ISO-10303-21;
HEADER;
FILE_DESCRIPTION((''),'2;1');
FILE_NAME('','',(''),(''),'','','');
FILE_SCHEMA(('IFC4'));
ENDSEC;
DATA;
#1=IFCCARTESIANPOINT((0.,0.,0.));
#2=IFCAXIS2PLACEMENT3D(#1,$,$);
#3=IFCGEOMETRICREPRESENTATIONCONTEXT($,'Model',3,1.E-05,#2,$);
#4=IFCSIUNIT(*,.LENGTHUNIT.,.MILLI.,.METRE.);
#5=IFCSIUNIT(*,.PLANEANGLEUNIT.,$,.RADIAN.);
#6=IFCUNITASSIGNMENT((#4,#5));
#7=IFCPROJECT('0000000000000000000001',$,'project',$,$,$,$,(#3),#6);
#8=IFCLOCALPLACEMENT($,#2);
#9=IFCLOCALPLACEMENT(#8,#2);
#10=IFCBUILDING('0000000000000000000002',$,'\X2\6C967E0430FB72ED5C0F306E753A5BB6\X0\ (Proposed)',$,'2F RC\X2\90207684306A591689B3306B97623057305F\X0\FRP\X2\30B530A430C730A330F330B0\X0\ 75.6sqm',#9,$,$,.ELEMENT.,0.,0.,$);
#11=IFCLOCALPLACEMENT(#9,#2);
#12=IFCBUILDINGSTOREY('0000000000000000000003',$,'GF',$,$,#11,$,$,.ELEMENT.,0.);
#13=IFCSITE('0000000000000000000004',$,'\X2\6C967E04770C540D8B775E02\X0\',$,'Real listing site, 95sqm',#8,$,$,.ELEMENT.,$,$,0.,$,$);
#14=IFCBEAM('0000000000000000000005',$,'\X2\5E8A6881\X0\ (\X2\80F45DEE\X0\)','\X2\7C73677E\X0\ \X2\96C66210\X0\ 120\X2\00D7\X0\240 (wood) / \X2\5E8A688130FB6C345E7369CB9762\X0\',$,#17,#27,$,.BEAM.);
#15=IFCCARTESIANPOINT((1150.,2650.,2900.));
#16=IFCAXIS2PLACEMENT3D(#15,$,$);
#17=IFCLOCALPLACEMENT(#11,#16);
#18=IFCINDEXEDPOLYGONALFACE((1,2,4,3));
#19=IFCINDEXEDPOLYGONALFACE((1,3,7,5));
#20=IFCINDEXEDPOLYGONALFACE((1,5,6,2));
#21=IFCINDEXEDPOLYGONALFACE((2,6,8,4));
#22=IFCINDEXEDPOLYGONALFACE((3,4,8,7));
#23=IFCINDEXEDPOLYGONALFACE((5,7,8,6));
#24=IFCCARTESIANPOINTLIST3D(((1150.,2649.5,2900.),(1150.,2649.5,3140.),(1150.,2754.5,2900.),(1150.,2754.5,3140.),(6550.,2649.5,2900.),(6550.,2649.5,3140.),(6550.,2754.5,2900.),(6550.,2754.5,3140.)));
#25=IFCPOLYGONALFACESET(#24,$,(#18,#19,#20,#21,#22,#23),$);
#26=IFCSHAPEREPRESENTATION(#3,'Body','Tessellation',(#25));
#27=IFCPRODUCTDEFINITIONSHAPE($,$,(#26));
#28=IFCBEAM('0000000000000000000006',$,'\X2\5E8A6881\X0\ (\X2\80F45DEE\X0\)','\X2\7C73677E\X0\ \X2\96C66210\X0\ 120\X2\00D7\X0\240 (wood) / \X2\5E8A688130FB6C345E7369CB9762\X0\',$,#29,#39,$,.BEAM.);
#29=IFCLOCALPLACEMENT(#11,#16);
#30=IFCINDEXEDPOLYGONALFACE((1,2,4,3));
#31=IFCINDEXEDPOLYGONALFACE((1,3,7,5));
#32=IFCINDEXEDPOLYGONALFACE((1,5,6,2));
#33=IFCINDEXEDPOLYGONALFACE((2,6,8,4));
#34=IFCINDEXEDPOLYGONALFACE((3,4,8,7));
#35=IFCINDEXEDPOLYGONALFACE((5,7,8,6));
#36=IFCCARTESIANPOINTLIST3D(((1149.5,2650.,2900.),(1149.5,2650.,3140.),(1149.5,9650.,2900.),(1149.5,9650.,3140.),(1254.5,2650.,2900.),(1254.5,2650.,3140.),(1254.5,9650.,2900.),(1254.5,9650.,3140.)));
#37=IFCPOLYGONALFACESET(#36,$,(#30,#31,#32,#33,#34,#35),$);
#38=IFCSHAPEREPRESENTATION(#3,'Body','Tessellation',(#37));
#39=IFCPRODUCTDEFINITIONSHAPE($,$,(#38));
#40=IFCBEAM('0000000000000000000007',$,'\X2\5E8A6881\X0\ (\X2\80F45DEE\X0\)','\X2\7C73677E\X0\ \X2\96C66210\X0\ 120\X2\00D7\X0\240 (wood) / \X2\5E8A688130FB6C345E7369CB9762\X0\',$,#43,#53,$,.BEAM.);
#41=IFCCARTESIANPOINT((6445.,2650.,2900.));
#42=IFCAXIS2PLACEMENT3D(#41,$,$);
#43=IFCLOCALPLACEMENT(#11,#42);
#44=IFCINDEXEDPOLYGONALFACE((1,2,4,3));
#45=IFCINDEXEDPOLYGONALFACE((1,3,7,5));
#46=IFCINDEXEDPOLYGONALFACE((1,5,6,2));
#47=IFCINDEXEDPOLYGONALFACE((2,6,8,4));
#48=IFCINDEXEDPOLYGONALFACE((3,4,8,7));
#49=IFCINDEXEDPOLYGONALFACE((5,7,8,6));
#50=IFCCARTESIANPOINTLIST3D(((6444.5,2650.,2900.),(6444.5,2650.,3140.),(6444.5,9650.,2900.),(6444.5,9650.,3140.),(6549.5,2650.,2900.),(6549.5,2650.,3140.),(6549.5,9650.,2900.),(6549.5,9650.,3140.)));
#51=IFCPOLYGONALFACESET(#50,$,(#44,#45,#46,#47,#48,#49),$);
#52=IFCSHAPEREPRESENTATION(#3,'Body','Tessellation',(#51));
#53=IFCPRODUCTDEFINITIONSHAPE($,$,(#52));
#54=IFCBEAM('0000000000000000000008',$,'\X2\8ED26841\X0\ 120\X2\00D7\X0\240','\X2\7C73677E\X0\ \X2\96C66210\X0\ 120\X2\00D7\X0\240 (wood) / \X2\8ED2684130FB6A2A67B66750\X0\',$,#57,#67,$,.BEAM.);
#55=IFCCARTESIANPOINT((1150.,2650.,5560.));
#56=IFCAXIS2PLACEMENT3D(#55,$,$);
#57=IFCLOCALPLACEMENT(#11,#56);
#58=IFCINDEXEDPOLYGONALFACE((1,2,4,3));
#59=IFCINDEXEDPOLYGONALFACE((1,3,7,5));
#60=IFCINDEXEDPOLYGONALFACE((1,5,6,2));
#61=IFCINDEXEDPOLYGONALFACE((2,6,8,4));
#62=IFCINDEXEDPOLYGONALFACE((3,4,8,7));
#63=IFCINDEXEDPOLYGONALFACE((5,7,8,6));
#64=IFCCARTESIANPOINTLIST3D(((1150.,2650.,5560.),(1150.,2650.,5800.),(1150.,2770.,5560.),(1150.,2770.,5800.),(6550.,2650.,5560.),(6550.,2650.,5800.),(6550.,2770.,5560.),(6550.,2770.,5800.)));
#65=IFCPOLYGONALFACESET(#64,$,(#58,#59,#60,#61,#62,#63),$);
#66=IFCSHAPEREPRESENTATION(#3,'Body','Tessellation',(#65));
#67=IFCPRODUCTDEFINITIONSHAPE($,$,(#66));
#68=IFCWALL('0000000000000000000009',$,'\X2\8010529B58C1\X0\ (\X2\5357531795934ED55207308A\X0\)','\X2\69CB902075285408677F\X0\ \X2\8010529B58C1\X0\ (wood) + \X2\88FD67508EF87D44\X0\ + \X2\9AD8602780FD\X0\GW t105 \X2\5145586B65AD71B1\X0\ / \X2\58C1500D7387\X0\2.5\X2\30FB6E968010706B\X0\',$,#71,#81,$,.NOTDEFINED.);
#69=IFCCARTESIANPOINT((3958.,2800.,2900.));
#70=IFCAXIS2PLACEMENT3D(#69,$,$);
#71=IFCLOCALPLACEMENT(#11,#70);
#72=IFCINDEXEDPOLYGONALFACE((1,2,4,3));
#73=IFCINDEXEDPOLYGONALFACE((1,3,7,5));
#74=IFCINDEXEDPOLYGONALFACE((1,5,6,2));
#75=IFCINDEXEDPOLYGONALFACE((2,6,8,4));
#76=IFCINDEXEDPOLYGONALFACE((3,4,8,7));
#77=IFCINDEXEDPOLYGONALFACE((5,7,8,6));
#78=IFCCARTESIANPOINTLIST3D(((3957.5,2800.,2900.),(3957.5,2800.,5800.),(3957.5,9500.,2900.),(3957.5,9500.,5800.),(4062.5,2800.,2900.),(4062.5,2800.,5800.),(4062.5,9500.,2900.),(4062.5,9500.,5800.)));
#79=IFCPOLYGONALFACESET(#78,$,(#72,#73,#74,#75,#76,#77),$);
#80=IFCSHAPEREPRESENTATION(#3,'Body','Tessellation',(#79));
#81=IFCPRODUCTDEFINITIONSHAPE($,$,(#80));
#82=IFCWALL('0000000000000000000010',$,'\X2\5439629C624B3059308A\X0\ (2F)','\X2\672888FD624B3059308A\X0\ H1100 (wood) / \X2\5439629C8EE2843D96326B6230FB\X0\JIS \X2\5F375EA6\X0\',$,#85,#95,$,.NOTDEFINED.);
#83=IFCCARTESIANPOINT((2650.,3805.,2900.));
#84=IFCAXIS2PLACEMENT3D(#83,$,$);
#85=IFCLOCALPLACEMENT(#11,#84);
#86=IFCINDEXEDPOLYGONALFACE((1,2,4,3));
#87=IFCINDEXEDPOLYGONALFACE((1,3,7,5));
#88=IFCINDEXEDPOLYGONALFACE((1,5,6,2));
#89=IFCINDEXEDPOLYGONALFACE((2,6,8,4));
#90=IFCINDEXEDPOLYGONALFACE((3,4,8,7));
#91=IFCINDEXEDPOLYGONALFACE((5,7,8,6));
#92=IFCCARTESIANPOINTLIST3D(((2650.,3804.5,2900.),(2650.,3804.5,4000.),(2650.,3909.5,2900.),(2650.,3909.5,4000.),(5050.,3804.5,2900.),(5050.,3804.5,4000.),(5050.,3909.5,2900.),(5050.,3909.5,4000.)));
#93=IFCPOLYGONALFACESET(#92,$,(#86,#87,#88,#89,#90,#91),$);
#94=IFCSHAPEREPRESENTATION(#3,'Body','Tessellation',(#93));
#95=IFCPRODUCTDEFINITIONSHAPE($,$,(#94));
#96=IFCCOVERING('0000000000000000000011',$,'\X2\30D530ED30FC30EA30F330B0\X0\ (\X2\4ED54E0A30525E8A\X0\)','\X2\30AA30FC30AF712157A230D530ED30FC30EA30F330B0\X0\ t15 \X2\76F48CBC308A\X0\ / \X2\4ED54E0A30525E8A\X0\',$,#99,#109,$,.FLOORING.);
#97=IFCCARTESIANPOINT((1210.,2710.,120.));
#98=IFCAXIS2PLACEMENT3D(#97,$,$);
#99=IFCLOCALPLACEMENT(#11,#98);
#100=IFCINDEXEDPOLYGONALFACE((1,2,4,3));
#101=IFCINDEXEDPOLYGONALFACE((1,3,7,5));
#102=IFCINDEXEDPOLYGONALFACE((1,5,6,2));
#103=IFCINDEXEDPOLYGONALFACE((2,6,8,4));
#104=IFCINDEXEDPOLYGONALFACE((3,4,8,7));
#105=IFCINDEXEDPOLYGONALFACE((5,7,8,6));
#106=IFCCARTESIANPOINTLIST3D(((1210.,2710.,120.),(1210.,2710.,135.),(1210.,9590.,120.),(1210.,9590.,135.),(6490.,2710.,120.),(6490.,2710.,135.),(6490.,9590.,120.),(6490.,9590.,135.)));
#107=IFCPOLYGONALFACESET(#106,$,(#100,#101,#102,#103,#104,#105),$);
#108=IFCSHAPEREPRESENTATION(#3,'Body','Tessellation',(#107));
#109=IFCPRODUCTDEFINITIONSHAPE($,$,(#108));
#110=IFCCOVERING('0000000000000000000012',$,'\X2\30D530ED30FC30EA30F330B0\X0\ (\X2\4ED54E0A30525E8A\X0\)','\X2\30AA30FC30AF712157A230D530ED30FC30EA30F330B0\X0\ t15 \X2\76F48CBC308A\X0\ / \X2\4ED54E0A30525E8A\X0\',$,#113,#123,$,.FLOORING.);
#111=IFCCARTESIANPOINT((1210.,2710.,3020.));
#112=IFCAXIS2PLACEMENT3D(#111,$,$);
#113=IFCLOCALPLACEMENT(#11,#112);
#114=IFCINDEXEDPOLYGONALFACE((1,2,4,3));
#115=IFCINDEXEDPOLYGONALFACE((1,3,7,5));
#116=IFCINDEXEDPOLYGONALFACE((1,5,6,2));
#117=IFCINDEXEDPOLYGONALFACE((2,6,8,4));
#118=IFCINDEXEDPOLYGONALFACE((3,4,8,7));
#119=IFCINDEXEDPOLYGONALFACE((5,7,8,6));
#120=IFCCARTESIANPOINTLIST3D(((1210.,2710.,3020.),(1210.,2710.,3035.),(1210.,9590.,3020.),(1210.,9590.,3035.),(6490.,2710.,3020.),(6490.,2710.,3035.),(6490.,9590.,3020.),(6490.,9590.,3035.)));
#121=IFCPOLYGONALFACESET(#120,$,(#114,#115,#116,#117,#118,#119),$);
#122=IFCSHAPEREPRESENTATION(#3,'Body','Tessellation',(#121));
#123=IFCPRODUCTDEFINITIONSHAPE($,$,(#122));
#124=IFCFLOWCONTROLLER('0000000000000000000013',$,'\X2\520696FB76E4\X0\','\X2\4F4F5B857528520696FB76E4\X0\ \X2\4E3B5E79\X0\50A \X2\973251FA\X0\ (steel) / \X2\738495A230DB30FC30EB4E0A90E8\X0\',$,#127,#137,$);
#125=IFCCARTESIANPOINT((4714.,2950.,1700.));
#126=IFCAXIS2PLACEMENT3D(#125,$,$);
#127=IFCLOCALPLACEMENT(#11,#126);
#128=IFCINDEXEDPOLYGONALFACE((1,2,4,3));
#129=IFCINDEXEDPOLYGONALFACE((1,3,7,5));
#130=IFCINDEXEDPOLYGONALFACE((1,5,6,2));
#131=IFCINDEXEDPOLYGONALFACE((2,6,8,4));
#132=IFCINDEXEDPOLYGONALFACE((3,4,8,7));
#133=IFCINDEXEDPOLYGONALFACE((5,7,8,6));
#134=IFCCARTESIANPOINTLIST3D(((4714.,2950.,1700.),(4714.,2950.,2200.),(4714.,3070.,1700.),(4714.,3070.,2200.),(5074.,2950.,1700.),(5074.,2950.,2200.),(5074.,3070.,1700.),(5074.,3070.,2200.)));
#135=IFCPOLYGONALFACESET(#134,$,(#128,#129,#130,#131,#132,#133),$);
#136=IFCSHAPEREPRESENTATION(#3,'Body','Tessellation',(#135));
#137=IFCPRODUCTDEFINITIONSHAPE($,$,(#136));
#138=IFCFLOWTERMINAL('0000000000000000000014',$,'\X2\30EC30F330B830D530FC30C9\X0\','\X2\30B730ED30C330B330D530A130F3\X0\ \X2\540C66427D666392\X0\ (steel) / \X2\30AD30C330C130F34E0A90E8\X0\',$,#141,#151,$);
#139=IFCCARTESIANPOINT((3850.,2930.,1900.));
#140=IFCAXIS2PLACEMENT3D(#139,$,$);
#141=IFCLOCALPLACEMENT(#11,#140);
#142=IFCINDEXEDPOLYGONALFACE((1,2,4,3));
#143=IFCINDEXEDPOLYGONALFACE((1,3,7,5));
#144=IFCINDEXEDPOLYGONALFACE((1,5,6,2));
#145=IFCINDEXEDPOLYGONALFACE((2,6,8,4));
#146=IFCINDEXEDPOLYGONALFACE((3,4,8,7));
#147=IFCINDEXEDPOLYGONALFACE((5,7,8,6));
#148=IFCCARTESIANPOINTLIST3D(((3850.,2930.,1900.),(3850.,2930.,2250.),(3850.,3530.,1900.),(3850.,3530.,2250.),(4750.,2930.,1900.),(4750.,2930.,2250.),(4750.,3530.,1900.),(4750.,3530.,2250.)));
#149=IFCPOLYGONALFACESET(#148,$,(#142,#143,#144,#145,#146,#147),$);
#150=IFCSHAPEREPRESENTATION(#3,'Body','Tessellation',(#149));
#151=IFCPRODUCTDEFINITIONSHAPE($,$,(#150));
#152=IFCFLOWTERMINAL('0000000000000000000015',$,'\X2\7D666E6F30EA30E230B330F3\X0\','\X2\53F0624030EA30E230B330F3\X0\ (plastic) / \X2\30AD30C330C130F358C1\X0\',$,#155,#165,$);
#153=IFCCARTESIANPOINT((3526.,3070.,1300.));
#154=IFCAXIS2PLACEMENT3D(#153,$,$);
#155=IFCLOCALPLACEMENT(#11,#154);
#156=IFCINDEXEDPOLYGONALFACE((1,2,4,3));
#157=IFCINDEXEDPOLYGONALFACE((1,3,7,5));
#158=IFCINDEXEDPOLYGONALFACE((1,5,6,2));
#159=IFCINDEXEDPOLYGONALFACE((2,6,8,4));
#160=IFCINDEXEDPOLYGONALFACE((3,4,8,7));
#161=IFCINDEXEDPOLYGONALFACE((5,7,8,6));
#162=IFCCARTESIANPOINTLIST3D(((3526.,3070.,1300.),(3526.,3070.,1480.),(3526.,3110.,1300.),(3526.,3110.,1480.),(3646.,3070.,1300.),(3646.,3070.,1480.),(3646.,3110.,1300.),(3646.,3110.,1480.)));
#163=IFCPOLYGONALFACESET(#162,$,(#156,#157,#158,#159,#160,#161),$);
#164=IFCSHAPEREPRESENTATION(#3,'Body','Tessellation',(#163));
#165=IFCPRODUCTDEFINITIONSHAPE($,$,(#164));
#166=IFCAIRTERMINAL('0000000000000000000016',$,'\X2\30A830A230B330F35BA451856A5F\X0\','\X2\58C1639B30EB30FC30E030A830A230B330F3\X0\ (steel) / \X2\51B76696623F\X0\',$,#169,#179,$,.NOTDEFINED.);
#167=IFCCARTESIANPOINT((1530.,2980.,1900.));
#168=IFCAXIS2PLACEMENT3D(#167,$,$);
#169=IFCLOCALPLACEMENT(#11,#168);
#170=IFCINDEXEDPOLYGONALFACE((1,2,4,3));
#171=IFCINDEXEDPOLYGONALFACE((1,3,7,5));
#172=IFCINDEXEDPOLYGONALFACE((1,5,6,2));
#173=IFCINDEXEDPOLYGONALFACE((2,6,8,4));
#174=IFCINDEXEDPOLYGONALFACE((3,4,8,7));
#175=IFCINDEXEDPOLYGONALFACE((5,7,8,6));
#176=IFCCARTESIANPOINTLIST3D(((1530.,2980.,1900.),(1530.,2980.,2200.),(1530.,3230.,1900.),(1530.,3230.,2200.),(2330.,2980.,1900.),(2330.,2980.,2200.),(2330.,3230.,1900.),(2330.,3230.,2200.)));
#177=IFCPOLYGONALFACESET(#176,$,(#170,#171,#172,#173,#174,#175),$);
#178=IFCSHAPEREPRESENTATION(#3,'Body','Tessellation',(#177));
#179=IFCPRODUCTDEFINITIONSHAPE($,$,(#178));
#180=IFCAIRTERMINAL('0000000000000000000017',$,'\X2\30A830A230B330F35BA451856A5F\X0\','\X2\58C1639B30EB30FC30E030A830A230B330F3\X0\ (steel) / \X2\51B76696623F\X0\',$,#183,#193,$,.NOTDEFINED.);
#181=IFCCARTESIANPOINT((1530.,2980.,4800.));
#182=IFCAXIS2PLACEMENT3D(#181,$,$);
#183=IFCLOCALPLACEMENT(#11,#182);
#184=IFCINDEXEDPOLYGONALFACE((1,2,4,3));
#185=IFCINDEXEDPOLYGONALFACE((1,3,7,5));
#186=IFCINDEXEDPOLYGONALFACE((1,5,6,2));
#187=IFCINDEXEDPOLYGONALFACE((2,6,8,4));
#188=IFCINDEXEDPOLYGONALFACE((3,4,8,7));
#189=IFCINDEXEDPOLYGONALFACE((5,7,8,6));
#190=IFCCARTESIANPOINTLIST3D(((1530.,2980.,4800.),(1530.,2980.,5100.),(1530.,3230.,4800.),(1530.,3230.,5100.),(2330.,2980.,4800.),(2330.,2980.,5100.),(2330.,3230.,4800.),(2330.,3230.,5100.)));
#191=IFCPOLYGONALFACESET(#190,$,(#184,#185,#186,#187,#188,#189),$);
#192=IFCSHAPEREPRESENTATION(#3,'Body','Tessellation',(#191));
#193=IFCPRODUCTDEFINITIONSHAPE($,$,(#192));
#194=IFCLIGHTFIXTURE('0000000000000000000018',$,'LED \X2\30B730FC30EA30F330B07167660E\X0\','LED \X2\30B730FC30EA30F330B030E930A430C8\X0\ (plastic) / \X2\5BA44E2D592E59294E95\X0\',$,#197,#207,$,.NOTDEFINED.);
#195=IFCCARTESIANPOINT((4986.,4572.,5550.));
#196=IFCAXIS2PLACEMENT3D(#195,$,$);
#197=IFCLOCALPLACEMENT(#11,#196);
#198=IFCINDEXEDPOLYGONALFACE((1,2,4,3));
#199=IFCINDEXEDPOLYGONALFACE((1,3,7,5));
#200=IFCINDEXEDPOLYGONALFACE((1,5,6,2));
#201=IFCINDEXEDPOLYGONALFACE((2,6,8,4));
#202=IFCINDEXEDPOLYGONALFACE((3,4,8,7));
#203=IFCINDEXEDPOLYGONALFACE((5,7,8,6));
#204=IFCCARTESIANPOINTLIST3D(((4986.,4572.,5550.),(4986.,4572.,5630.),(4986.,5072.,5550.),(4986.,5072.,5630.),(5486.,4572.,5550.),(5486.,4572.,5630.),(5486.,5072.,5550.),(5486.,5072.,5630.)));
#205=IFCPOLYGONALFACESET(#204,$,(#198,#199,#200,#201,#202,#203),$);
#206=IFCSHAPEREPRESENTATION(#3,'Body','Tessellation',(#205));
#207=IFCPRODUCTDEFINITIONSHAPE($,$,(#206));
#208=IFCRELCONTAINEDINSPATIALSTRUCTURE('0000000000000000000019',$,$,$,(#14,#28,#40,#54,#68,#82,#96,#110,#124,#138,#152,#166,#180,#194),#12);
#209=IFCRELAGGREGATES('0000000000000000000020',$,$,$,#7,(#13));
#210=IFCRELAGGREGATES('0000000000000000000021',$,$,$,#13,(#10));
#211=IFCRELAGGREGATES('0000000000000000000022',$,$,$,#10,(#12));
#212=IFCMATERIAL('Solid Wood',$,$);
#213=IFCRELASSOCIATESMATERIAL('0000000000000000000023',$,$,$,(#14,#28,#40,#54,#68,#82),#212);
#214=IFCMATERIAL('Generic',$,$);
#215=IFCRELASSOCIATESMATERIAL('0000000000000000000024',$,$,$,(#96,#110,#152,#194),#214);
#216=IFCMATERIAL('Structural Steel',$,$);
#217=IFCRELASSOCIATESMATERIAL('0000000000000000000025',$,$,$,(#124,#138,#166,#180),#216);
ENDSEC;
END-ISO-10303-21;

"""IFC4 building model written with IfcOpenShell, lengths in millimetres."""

from ifc_helpers import new_model, si_unit, frame, frame_2d, origin, place, context, project, spatial, rectangle, extrude, material, element, save


model = new_model("IFC4")

# Units and contexts
model_context = context("Model", 3, precision=1e-05, world=origin())
ifc_project = project(units=[si_unit("LENGTHUNIT", "METRE", prefix="MILLI"), si_unit("PLANEANGLEUNIT", "RADIAN")], contexts=[model_context])

# Site, building, storey
site_placement = place(None, origin())
site = spatial("IfcSite", under=ifc_project, at=site_placement, Name="沖縄県名護市", ObjectType="Real listing site, 95sqm", CompositionType="ELEMENT", RefElevation=0.0)
building_placement = place(site_placement, origin())
building = spatial("IfcBuilding", under=site, at=building_placement, Name="沖縄・狭小の町家 (Proposed)", ObjectType="2F RC造的な外観に面したFRPサイディング 75.6sqm", CompositionType="ELEMENT", ElevationOfRefHeight=0.0, ElevationOfTerrain=0.0)
storey_placement = place(building_placement, origin())
storey = spatial("IfcBuildingStorey", under=building, at=storey_placement, Name="GF", CompositionType="ELEMENT", Elevation=0.0)

# Shared definitions
ifc_material_1 = material(Name="Solid Wood")

# Beams
beam_1_placement = place(storey_placement, frame((1150.0, 2650.0, 2900.0)))
element("IfcBeam", 1, at=beam_1_placement, inside=storey, material=ifc_material_1, Name="床梁 (胴差)", Description="米松 集成 120×240 (wood) / 床梁・水平構面", PredefinedType="BEAM", context=model_context, shape_type="SweptSolid", body=[
    extrude(rectangle(XDim=5400.0, YDim=105.0, at=frame_2d((2700.0, 52.0))), frame((1150.0, 2650.0, 2900.0)), (0.0, 0.0, 1.0), 240.0),
])
beam_2_placement = place(storey_placement, frame((1150.0, 2650.0, 2900.0)))
element("IfcBeam", 2, at=beam_2_placement, inside=storey, material=ifc_material_1, Name="床梁 (胴差)", Description="米松 集成 120×240 (wood) / 床梁・水平構面", PredefinedType="BEAM", context=model_context, shape_type="SweptSolid", body=[
    extrude(rectangle(XDim=105.0, YDim=7000.0, at=frame_2d((52.0, 3500.0))), frame((1150.0, 2650.0, 2900.0)), (0.0, 0.0, 1.0), 240.0),
])
beam_3_placement = place(storey_placement, frame((6445.0, 2650.0, 2900.0)))
element("IfcBeam", 3, at=beam_3_placement, inside=storey, material=ifc_material_1, Name="床梁 (胴差)", Description="米松 集成 120×240 (wood) / 床梁・水平構面", PredefinedType="BEAM", context=model_context, shape_type="SweptSolid", body=[
    extrude(rectangle(XDim=105.0, YDim=7000.0, at=frame_2d((52.0, 3500.0))), frame((6445.0, 2650.0, 2900.0)), (0.0, 0.0, 1.0), 240.0),
])
beam_4_placement = place(storey_placement, frame((1150.0, 2650.0, 5560.0)))
element("IfcBeam", 4, at=beam_4_placement, inside=storey, material=ifc_material_1, Name="軒桁 120×240", Description="米松 集成 120×240 (wood) / 軒桁・横架材", PredefinedType="BEAM", context=model_context, shape_type="SweptSolid", body=[
    extrude(rectangle(XDim=5400.0, YDim=120.0, at=frame_2d((2700.0, 60.0))), frame((1150.0, 2650.0, 5560.0)), (0.0, 0.0, 1.0), 240.0),
])

# Walls
wall_1_placement = place(storey_placement, frame((3958.0, 2800.0, 2900.0)))
element("IfcWall", 5, at=wall_1_placement, inside=storey, material=ifc_material_1, Name="耐力壁 (南北間仕切り)", Description="構造用合板 耐力壁 (wood) + 製材軸組 + 高性能GW t105 充填断熱 / 壁倍率2.5・準耐火", PredefinedType="NOTDEFINED", context=model_context, shape_type="SweptSolid", body=[
    extrude(rectangle(XDim=105.0, YDim=6700.0, at=frame_2d((52.0, 3350.0))), frame((3958.0, 2800.0, 2900.0)), (0.0, 0.0, 1.0), 2900.0),
])
wall_2_placement = place(storey_placement, frame((2650.0, 3805.0, 2900.0)))
element("IfcWall", 6, at=wall_2_placement, inside=storey, material=ifc_material_1, Name="吹抜手すり (2F)", Description="木製手すり H1100 (wood) / 吹抜転落防止・JIS 強度", PredefinedType="NOTDEFINED", context=model_context, shape_type="SweptSolid", body=[
    extrude(rectangle(XDim=2400.0, YDim=105.0, at=frame_2d((1200.0, 52.0))), frame((2650.0, 3805.0, 2900.0)), (0.0, 0.0, 1.0), 1100.0),
])

# Coverings
ifc_material_2 = material(Name="Generic")
covering_1_placement = place(storey_placement, frame((1210.0, 2710.0, 120.0)))
element("IfcCovering", 7, at=covering_1_placement, inside=storey, material=ifc_material_2, Name="フローリング (仕上げ床)", Description="オーク無垢フローリング t15 直貼り / 仕上げ床", PredefinedType="FLOORING", context=model_context, shape_type="SweptSolid", body=[
    extrude(rectangle(XDim=5280.0, YDim=6880.0, at=frame_2d((2640.0, 3440.0))), frame((1210.0, 2710.0, 120.0)), (0.0, 0.0, 1.0), 15.0),
])
covering_2_placement = place(storey_placement, frame((1210.0, 2710.0, 3020.0)))
element("IfcCovering", 8, at=covering_2_placement, inside=storey, material=ifc_material_2, Name="フローリング (仕上げ床)", Description="オーク無垢フローリング t15 直貼り / 仕上げ床", PredefinedType="FLOORING", context=model_context, shape_type="SweptSolid", body=[
    extrude(rectangle(XDim=5280.0, YDim=6880.0, at=frame_2d((2640.0, 3440.0))), frame((1210.0, 2710.0, 3020.0)), (0.0, 0.0, 1.0), 15.0),
])

# Flow controller
ifc_material_3 = material(Name="Structural Steel")
flow_controller_placement = place(storey_placement, frame((4714.0, 2950.0, 1700.0)))
element("IfcFlowController", 9, at=flow_controller_placement, inside=storey, material=ifc_material_3, Name="分電盤", Description="住宅用分電盤 主幹50A 露出 (steel) / 玄関ホール上部", context=model_context, shape_type="SweptSolid", body=[
    extrude(rectangle(XDim=360.0, YDim=120.0, at=frame_2d((180.0, 60.0))), frame((4714.0, 2950.0, 1700.0)), (0.0, 0.0, 1.0), 500.0),
])

# Flow terminals
flow_terminal_1_placement = place(storey_placement, frame((3850.0, 2930.0, 1900.0)))
element("IfcFlowTerminal", 10, at=flow_terminal_1_placement, inside=storey, material=ifc_material_3, Name="レンジフード", Description="シロッコファン 同時給排 (steel) / キッチン上部", context=model_context, shape_type="SweptSolid", body=[
    extrude(rectangle(XDim=900.0, YDim=600.0, at=frame_2d((450.0, 300.0))), frame((3850.0, 2930.0, 1900.0)), (0.0, 0.0, 1.0), 350.0),
])
flow_terminal_2_placement = place(storey_placement, frame((3526.0, 3070.0, 1300.0)))
element("IfcFlowTerminal", 11, at=flow_terminal_2_placement, inside=storey, material=ifc_material_2, Name="給湯リモコン", Description="台所リモコン (plastic) / キッチン壁", context=model_context, shape_type="SweptSolid", body=[
    extrude(rectangle(XDim=120.0, YDim=40.0, at=frame_2d((60.0, 20.0))), frame((3526.0, 3070.0, 1300.0)), (0.0, 0.0, 1.0), 180.0),
])

# Air terminals
air_terminal_1_placement = place(storey_placement, frame((1530.0, 2980.0, 1900.0)))
element("IfcAirTerminal", 12, at=air_terminal_1_placement, inside=storey, material=ifc_material_3, Name="エアコン室内機", Description="壁掛ルームエアコン (steel) / 冷暖房", PredefinedType="NOTDEFINED", context=model_context, shape_type="SweptSolid", body=[
    extrude(rectangle(XDim=800.0, YDim=250.0, at=frame_2d((400.0, 125.0))), frame((1530.0, 2980.0, 1900.0)), (0.0, 0.0, 1.0), 300.0),
])
air_terminal_2_placement = place(storey_placement, frame((1530.0, 2980.0, 4800.0)))
element("IfcAirTerminal", 13, at=air_terminal_2_placement, inside=storey, material=ifc_material_3, Name="エアコン室内機", Description="壁掛ルームエアコン (steel) / 冷暖房", PredefinedType="NOTDEFINED", context=model_context, shape_type="SweptSolid", body=[
    extrude(rectangle(XDim=800.0, YDim=250.0, at=frame_2d((400.0, 125.0))), frame((1530.0, 2980.0, 4800.0)), (0.0, 0.0, 1.0), 300.0),
])

# Light fixture
light_fixture_placement = place(storey_placement, frame((4986.0, 4572.0, 5550.0)))
element("IfcLightFixture", 14, at=light_fixture_placement, inside=storey, material=ifc_material_2, Name="LED シーリング照明", Description="LED シーリングライト (plastic) / 室中央天井", PredefinedType="NOTDEFINED", context=model_context, shape_type="SweptSolid", body=[
    extrude(rectangle(XDim=500.0, YDim=500.0, at=frame_2d((250.0, 250.0))), frame((4986.0, 4572.0, 5550.0)), (0.0, 0.0, 1.0), 80.0),
])

save(model, "model.ifc")
